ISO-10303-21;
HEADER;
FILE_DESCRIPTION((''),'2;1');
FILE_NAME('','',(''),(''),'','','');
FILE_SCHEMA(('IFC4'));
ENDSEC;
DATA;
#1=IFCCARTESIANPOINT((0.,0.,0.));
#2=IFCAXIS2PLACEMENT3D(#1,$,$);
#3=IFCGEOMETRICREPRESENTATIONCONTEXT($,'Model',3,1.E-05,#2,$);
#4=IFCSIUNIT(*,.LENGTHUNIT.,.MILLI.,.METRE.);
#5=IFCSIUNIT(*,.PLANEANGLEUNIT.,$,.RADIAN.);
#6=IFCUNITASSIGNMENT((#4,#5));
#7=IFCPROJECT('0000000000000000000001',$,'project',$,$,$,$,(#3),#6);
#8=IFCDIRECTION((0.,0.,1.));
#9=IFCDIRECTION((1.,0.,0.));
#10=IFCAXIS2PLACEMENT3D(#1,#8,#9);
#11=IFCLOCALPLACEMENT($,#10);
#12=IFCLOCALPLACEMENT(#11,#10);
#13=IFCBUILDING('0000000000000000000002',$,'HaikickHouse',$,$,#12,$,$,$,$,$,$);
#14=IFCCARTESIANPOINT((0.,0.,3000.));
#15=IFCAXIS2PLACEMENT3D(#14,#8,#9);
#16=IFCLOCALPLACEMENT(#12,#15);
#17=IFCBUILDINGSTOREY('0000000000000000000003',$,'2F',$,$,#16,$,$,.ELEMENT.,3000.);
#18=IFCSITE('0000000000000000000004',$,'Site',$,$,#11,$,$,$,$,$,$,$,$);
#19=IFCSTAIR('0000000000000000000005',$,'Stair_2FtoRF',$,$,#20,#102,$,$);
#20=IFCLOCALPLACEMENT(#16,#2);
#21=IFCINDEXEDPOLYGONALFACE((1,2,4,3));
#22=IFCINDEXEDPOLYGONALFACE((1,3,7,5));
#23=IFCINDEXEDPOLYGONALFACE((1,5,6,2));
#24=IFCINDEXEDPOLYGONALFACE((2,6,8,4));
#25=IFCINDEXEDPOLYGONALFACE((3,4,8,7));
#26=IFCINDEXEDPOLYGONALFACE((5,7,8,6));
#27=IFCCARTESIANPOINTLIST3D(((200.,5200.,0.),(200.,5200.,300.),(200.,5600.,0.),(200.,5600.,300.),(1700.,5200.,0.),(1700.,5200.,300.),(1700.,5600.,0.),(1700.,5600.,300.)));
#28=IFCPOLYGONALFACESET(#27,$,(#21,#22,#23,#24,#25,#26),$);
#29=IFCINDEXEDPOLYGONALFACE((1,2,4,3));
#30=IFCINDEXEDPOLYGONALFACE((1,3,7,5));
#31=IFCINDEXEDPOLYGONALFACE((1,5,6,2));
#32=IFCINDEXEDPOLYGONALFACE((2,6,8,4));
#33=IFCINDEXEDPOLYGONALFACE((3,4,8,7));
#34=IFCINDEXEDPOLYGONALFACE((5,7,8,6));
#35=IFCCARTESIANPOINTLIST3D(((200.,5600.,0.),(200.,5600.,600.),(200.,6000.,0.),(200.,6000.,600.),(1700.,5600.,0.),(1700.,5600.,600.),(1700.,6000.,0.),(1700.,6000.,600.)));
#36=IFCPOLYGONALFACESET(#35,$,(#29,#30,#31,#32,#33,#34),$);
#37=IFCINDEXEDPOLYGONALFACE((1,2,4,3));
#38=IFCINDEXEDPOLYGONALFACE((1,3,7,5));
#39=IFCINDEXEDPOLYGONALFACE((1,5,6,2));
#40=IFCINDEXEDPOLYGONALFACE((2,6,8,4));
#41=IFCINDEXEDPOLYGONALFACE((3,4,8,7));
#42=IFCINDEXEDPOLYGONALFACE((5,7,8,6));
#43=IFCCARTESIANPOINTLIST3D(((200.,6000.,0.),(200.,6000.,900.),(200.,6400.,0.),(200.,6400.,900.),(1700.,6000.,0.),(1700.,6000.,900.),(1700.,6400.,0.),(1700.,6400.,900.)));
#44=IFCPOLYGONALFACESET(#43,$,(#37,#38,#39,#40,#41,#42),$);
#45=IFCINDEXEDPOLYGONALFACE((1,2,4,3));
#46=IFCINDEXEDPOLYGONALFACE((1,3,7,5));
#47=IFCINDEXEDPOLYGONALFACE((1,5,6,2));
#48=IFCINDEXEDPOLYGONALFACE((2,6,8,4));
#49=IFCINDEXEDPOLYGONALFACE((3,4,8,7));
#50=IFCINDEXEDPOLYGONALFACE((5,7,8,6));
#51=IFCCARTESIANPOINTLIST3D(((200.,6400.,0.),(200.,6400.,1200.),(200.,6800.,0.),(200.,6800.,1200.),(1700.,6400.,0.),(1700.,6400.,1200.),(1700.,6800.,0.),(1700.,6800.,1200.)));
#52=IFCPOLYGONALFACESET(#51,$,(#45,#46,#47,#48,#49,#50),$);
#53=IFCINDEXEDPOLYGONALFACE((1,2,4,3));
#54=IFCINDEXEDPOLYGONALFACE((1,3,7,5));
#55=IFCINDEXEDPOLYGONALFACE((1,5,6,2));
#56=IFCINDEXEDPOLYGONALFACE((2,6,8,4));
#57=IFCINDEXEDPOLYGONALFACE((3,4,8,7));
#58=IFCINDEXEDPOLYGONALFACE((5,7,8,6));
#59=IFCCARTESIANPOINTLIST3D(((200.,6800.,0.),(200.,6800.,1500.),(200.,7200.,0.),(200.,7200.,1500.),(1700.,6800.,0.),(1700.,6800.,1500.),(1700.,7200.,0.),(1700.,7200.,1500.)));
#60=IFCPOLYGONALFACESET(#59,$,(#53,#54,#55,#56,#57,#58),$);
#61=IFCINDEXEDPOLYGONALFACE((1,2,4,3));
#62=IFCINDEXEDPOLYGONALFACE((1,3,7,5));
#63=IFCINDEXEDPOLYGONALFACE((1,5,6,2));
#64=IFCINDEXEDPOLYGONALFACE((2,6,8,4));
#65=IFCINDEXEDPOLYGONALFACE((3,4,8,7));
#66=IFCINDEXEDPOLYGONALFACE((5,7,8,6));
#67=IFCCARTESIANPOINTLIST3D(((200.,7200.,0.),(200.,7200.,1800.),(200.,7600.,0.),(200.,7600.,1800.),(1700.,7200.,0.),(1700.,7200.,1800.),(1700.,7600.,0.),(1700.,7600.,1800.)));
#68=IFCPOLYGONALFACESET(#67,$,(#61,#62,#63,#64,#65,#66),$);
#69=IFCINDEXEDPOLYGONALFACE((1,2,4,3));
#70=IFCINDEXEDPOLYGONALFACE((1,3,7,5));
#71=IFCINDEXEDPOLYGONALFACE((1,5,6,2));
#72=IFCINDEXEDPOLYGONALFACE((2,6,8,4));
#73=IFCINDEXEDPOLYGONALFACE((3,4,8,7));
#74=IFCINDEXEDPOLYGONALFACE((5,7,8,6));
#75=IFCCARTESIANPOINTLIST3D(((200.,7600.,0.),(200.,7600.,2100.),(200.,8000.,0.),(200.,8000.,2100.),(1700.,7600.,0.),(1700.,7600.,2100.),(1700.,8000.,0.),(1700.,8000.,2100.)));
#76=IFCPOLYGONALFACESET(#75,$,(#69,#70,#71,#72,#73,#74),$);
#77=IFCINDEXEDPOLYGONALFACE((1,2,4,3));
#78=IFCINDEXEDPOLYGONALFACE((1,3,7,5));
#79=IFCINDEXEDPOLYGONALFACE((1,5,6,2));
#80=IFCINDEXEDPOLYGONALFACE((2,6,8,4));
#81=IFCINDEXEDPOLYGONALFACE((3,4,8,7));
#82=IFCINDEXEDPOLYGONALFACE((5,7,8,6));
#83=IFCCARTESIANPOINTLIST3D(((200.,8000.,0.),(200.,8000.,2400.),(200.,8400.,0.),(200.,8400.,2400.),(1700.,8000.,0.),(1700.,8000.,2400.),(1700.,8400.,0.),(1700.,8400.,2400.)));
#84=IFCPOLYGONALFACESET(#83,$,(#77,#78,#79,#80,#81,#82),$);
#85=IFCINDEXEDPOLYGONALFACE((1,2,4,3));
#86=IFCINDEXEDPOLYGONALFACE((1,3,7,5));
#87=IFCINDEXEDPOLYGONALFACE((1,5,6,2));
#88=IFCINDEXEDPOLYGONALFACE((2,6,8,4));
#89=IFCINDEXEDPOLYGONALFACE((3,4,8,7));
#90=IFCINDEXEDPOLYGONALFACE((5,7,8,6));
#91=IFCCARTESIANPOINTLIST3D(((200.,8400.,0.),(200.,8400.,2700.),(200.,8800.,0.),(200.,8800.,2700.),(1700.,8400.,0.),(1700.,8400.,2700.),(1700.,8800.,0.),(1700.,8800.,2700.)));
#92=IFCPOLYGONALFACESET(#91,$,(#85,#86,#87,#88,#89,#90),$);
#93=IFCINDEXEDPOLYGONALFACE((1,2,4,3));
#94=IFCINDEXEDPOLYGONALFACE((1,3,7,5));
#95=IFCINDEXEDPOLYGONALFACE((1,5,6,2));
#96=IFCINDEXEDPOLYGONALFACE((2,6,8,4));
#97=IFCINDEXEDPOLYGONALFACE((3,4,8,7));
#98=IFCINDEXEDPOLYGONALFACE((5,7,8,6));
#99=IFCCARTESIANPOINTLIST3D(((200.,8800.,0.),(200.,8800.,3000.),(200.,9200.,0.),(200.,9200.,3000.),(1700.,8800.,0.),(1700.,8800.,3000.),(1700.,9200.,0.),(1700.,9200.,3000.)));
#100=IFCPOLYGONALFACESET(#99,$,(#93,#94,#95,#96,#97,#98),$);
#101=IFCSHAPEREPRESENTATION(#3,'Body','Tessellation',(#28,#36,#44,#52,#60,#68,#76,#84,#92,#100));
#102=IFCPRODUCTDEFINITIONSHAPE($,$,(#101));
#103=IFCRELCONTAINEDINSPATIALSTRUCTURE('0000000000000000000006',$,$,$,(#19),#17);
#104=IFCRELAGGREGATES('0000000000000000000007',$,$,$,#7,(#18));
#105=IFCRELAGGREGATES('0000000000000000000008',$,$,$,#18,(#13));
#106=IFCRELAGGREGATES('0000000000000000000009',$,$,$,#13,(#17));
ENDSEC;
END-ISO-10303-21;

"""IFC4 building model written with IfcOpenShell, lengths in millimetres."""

from ifc_helpers import new_model, si_unit, frame, origin, origin_with_axes, place, context, project, spatial, rectangle, extrude, element, save


model = new_model("IFC4")

# Units and contexts
model_context = context("Model", 3, precision=1e-05, world=origin())
ifc_project = project(units=[si_unit("LENGTHUNIT", "METRE", prefix="MILLI"), si_unit("PLANEANGLEUNIT", "RADIAN")], contexts=[model_context])

# Site, building, storey
site_placement = place(None, origin_with_axes())
site = spatial("IfcSite", under=ifc_project, at=site_placement, Name="Site")
building_placement = place(site_placement, origin_with_axes())
building = spatial("IfcBuilding", under=site, at=building_placement, Name="HaikickHouse")
storey_placement = place(building_placement, frame((0.0, 0.0, 3000.0), z_axis=(0.0, 0.0, 1.0), x_axis=(1.0, 0.0, 0.0)))
storey = spatial("IfcBuildingStorey", under=building, at=storey_placement, Name="2F", CompositionType="ELEMENT", Elevation=3000.0)

# Stair
stair_placement = place(None, frame((200.0, 5200.0, 3000.0), z_axis=(0.0, 0.0, 1.0), x_axis=(1.0, 0.0, 0.0)))
element("IfcStair", 1, at=stair_placement, inside=storey, Name="Stair_2FtoRF", context=model_context, shape_type="SweptSolid", body=[
    extrude(rectangle(XDim=1500.0, YDim=400.0), frame((750.0, 200.0, 0.0)), (0.0, 0.0, 1.0), 300.0),
    extrude(rectangle(XDim=1500.0, YDim=400.0), frame((750.0, 600.0, 0.0)), (0.0, 0.0, 1.0), 600.0),
    extrude(rectangle(XDim=1500.0, YDim=400.0), frame((750.0, 1000.0, 0.0)), (0.0, 0.0, 1.0), 900.0),
    extrude(rectangle(XDim=1500.0, YDim=400.0), frame((750.0, 1400.0, 0.0)), (0.0, 0.0, 1.0), 1200.0),
    extrude(rectangle(XDim=1500.0, YDim=400.0), frame((750.0, 1800.0, 0.0)), (0.0, 0.0, 1.0), 1500.0),
    extrude(rectangle(XDim=1500.0, YDim=400.0), frame((750.0, 2200.0, 0.0)), (0.0, 0.0, 1.0), 1800.0),
    extrude(rectangle(XDim=1500.0, YDim=400.0), frame((750.0, 2600.0, 0.0)), (0.0, 0.0, 1.0), 2100.0),
    extrude(rectangle(XDim=1500.0, YDim=400.0), frame((750.0, 3000.0, 0.0)), (0.0, 0.0, 1.0), 2400.0),
    extrude(rectangle(XDim=1500.0, YDim=400.0), frame((750.0, 3400.0, 0.0)), (0.0, 0.0, 1.0), 2700.0),
    extrude(rectangle(XDim=1500.0, YDim=400.0), frame((750.0, 3800.0, 0.0)), (0.0, 0.0, 1.0), 3000.0),
])

save(model, "model.ifc")
